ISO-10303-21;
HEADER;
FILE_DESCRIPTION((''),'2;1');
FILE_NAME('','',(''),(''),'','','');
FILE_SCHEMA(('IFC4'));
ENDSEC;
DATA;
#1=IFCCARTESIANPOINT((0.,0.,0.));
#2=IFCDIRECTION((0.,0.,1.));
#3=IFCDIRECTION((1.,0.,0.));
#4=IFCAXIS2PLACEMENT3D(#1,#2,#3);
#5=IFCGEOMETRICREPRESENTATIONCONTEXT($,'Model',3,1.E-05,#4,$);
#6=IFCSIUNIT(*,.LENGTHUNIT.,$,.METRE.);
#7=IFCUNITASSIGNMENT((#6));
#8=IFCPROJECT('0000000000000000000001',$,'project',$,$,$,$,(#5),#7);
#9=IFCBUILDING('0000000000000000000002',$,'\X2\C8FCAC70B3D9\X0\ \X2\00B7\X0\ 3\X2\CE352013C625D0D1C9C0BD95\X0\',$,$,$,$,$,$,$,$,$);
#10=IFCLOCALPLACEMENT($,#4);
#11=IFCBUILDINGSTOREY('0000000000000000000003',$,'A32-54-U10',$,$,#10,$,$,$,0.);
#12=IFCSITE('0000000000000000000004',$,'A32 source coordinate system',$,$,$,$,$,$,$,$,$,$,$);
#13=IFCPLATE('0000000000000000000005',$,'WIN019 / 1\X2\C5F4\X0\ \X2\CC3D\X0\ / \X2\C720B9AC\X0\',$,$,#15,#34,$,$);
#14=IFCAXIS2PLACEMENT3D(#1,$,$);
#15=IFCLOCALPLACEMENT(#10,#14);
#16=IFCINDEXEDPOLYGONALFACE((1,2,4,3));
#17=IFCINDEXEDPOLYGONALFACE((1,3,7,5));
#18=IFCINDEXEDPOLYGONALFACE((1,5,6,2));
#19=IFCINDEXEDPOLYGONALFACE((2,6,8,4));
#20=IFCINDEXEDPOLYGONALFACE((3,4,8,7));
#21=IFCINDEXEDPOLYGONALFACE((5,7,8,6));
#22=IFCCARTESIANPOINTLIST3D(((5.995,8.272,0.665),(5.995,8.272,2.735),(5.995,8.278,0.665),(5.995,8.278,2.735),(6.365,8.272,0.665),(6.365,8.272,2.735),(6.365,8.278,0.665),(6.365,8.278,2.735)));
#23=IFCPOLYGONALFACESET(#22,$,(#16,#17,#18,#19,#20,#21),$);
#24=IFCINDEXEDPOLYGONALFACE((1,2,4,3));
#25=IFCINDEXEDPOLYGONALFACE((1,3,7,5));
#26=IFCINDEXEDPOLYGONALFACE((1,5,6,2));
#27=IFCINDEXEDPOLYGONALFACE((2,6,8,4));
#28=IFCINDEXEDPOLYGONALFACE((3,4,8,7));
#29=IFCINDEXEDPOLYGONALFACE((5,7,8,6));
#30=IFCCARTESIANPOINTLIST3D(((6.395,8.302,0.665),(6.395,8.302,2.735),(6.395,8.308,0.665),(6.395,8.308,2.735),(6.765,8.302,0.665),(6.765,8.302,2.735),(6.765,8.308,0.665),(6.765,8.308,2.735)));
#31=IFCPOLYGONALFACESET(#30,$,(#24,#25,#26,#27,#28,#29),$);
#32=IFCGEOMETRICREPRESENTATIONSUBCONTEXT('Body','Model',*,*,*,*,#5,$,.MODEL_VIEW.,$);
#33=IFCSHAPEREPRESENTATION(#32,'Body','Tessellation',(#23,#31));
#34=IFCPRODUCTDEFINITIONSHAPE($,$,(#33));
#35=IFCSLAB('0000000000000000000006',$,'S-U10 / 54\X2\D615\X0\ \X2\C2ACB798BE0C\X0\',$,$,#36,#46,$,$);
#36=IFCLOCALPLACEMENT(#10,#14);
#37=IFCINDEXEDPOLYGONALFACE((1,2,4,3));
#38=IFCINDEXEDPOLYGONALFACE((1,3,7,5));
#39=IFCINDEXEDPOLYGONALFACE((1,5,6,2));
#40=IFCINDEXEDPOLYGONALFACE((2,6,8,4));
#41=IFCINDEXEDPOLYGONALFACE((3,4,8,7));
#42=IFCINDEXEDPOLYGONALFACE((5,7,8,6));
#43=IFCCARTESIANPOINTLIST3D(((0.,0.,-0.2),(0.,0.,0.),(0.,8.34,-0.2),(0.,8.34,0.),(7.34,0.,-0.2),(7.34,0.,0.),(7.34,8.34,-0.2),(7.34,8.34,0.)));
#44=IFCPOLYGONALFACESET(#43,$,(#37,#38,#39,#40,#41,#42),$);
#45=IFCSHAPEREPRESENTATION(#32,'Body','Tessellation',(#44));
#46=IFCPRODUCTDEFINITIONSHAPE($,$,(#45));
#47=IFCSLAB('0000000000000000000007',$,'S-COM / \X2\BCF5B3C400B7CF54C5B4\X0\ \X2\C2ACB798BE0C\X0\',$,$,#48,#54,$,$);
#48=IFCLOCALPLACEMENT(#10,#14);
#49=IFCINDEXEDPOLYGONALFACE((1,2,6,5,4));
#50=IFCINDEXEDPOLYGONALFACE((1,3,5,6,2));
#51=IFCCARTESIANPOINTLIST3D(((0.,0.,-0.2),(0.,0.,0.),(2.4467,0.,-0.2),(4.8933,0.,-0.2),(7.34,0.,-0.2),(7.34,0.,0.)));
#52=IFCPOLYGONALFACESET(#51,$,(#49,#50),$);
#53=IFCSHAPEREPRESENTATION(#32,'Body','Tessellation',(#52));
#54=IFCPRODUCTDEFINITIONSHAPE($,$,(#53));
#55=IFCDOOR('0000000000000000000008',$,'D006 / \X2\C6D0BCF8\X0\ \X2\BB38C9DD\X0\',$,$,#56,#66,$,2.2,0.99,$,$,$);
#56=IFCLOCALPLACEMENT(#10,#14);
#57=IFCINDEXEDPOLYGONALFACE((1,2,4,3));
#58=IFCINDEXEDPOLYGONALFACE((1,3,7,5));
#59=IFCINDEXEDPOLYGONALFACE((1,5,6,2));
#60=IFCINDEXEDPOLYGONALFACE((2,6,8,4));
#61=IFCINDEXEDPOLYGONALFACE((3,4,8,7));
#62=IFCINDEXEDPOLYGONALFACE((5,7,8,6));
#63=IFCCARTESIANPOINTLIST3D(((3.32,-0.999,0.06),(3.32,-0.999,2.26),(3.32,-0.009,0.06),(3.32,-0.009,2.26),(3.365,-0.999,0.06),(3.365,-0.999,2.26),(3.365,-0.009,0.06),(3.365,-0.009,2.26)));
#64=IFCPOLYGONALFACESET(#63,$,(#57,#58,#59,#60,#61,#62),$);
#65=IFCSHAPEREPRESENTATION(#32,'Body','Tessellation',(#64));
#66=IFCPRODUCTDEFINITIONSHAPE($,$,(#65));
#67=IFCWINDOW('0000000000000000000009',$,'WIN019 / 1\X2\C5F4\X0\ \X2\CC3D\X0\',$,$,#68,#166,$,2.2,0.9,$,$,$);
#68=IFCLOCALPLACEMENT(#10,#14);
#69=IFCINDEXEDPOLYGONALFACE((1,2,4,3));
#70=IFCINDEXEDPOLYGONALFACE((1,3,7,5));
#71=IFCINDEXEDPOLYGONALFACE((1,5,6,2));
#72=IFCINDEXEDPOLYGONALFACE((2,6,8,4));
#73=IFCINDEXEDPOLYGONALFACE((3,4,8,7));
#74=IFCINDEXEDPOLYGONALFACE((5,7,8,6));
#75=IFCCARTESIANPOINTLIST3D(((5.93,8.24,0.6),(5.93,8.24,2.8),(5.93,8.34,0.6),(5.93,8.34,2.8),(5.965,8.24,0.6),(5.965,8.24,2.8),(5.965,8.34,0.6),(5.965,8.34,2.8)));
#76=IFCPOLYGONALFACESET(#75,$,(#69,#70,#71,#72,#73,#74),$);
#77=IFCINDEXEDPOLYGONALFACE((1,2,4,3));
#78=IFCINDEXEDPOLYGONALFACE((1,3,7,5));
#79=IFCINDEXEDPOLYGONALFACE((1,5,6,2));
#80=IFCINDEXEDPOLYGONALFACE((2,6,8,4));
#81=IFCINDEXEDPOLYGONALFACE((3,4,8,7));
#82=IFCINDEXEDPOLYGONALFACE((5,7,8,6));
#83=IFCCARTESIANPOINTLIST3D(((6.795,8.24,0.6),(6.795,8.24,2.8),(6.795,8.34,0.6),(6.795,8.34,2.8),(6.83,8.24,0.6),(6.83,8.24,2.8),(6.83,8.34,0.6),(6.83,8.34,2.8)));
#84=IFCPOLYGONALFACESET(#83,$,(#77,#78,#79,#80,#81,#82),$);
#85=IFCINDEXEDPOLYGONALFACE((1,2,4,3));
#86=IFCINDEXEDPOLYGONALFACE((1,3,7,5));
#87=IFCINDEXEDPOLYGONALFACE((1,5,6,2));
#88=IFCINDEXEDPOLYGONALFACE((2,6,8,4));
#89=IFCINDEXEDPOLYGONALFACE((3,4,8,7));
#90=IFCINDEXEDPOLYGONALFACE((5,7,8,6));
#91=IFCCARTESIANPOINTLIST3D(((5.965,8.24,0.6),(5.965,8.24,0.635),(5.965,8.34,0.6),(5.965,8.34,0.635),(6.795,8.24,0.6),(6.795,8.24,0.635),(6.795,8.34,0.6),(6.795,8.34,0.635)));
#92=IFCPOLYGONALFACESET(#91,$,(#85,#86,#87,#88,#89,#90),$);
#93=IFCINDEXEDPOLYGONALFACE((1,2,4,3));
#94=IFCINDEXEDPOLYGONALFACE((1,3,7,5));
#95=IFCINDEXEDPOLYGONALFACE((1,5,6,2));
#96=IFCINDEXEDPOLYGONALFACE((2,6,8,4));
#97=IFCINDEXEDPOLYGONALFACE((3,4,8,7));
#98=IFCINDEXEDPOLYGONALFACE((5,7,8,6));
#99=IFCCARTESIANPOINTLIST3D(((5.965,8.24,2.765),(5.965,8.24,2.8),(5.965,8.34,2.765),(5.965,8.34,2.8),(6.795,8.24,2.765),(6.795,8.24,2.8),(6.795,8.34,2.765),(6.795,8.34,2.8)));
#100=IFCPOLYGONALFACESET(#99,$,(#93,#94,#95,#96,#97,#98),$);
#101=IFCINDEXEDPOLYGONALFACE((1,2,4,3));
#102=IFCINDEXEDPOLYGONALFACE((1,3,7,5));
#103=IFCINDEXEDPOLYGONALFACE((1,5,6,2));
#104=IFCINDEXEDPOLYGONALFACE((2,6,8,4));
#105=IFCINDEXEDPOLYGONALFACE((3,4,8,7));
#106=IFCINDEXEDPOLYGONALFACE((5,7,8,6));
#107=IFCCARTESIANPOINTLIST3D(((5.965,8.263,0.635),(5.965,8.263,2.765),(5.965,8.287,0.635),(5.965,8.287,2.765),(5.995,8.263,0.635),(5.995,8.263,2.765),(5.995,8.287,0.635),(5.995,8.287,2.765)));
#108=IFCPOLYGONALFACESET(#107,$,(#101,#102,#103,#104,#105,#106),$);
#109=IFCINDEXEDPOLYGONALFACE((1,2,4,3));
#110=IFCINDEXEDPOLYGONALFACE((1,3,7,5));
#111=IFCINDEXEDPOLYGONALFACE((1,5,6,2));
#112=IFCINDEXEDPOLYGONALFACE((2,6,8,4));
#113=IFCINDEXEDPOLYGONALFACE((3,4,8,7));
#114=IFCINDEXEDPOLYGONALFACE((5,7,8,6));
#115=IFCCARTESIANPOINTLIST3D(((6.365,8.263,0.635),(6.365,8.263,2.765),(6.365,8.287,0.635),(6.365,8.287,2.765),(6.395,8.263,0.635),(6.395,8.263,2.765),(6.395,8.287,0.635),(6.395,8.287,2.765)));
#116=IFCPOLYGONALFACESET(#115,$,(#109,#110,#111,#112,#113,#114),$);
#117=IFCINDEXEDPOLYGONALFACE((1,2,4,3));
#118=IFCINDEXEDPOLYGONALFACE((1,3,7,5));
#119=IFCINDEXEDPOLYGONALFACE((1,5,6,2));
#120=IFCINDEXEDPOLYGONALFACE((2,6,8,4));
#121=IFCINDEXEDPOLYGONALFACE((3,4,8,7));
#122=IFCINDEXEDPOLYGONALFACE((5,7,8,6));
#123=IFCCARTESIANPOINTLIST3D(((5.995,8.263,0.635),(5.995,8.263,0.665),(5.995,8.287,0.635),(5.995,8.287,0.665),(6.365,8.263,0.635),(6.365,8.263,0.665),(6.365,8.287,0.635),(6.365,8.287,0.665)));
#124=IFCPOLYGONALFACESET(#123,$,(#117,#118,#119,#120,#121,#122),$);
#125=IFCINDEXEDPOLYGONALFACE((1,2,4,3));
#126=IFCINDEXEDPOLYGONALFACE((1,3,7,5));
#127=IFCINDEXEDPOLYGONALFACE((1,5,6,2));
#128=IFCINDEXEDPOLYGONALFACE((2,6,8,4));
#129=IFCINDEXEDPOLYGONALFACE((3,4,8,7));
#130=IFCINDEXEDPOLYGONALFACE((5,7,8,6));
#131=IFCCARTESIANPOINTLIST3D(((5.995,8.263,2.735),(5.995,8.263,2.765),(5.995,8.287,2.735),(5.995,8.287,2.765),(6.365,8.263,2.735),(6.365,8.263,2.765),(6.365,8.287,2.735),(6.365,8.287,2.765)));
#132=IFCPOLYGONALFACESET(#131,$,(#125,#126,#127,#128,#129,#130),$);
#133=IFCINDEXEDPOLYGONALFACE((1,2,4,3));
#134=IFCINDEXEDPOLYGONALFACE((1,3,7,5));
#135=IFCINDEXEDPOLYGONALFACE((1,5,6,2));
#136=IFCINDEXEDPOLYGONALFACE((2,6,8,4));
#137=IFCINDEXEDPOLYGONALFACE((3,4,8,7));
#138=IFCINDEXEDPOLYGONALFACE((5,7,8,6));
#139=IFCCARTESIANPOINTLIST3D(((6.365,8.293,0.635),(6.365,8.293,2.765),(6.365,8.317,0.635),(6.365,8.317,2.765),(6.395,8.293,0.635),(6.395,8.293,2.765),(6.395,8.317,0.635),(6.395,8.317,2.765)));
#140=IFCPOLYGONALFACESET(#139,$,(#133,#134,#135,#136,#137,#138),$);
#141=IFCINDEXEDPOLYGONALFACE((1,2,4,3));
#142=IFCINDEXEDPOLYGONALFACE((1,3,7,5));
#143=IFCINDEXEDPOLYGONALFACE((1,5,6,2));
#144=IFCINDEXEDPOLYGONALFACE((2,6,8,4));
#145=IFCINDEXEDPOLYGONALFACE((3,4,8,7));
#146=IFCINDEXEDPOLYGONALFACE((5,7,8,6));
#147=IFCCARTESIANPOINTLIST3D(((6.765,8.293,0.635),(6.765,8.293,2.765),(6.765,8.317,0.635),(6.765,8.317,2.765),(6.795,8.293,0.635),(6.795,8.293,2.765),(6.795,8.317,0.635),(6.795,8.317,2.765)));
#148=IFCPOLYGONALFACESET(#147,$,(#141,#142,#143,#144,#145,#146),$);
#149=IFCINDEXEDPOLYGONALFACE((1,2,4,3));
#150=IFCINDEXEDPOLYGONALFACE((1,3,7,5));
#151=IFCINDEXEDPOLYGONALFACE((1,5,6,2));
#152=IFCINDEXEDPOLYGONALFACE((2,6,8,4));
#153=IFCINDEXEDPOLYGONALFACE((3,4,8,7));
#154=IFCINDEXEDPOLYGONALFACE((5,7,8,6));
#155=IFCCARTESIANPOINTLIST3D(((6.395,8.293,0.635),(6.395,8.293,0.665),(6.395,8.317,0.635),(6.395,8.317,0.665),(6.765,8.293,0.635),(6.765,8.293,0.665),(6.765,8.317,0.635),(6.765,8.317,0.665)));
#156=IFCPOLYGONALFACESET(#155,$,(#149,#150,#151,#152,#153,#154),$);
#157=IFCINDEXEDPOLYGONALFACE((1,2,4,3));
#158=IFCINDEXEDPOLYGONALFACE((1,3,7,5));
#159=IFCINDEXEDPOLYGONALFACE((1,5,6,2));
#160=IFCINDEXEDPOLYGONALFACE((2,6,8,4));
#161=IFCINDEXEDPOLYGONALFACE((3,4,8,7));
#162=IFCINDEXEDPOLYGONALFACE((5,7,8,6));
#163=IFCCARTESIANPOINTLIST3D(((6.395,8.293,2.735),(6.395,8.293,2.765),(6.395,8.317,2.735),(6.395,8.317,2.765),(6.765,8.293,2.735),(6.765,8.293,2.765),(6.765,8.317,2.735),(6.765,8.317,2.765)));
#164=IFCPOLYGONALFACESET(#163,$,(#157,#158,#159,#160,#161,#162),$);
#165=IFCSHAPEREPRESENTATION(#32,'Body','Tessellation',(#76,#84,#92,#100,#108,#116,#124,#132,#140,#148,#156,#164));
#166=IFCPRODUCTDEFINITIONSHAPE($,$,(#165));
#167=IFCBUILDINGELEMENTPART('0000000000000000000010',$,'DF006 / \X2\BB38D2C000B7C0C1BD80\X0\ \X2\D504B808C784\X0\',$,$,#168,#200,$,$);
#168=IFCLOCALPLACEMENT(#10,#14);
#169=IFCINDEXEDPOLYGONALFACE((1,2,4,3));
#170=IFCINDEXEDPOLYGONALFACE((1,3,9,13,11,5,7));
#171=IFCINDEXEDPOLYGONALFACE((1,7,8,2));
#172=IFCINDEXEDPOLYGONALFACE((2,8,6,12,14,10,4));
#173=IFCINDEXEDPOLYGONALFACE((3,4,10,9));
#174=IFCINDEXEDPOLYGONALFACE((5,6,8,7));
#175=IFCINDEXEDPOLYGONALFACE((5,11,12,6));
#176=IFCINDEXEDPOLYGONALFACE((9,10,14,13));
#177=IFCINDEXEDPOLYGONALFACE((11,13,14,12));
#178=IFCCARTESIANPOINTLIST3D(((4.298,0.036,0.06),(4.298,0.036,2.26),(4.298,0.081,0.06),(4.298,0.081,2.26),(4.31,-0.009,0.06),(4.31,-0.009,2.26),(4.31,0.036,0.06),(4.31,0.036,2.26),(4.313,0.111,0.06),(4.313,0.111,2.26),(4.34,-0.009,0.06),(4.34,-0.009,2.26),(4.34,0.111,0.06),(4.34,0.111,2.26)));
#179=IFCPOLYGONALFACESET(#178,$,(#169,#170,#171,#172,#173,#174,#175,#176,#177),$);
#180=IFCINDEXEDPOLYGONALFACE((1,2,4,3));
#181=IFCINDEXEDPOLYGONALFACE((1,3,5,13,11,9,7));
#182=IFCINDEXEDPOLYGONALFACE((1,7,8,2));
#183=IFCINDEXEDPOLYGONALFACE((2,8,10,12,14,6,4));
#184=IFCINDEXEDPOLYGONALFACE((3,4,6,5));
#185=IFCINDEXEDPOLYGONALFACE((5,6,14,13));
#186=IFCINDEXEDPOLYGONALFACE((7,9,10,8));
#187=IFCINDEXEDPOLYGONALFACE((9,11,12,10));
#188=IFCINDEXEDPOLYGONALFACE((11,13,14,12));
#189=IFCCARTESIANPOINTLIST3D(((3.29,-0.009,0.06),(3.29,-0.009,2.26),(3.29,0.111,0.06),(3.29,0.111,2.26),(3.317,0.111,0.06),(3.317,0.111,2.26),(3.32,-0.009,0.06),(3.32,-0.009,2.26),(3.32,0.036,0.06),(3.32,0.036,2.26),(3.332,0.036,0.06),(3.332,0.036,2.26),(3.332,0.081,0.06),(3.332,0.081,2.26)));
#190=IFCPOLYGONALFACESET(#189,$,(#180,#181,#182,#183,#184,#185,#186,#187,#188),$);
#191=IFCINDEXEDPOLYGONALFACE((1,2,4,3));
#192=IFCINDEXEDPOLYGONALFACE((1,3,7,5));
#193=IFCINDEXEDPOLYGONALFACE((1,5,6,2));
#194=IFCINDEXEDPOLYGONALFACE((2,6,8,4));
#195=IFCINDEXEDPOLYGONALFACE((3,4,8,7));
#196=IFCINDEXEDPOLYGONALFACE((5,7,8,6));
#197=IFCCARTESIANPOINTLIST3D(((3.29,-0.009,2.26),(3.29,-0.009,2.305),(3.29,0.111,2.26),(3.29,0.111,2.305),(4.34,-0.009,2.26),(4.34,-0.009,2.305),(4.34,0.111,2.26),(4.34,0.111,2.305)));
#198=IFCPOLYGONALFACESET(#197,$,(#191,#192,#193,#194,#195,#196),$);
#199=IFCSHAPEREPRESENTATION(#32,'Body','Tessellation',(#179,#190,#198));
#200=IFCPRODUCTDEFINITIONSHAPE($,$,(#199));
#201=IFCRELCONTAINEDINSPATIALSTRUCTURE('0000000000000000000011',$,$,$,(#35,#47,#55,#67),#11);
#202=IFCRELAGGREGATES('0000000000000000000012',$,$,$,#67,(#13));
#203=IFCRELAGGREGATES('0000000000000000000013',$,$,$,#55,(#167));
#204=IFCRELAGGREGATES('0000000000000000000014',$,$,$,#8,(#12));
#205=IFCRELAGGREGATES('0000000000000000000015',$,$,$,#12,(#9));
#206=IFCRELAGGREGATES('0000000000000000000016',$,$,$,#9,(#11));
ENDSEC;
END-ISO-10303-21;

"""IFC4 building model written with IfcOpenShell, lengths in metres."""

from ifc_helpers import new_model, si_unit, frame, origin_with_axes, place, context, subcontext, project, spatial, polyline, outline, extrude, element, aggregate, save


model = new_model("IFC4")

# Units and contexts
model_context = context("Model", 3, precision=1e-05, world=origin_with_axes())
body_context = subcontext(model_context, "Body", "Model", "MODEL_VIEW")
ifc_project = project(units=[si_unit("LENGTHUNIT", "METRE")], contexts=[model_context])

# Plate
storey_placement = place(None, origin_with_axes())
window_1_placement = place(storey_placement, origin_with_axes())
plate_1_placement = place(window_1_placement, origin_with_axes())
plate_1 = element("IfcPlate", 1, at=plate_1_placement, Name="WIN019 / 1열 창 / 유리", context=body_context, shape_type="SweptSolid", body=[
    extrude(outline(polyline([(5.995, 8.272), (5.995, 8.278), (6.365, 8.278), (6.365, 8.272), (5.995, 8.272)])), frame((0.0, 0.0, 0.665)), (0.0, 0.0, 1.0), 2.07),
    extrude(outline(polyline([(6.395, 8.302), (6.395, 8.308), (6.765, 8.308), (6.765, 8.302), (6.395, 8.302)])), frame((0.0, 0.0, 0.665)), (0.0, 0.0, 1.0), 2.07),
])

# Site, building, storey
site = spatial("IfcSite", under=ifc_project, Name="A32 source coordinate system")
building = spatial("IfcBuilding", under=site, Name="주거동 · 3층–옥탑지붕")
storey = spatial("IfcBuildingStorey", under=building, at=storey_placement, Name="A32-54-U10", Elevation=0.0)

# Slabs
slab_1_placement = place(storey_placement, origin_with_axes())
element("IfcSlab", 2, at=slab_1_placement, inside=storey, Name="S-U10 / 54형 슬래브", context=body_context, shape_type="SweptSolid", body=[
    extrude(outline(polyline([(0.0, 0.0), (0.0, 8.34), (7.34, 8.34), (7.34, 0.0), (0.0, 0.0)])), frame((0.0, 0.0, -0.2)), (0.0, 0.0, 1.0), 0.2),
])
slab_2_placement = place(storey_placement, origin_with_axes())
element("IfcSlab", 3, at=slab_2_placement, inside=storey, Name="S-COM / 복도·코어 슬래브", context=body_context, shape_type="SweptSolid", body=[
    extrude(outline(polyline([(7.34, 0.0), (7.34, 0.0), (0.0, 0.0), (0.0, 0.0), (7.34, 0.0)])), frame((0.0, 0.0, -0.2)), (0.0, 0.0, 1.0), 0.2),
])

# Door
door_1_placement = place(storey_placement, origin_with_axes())
door_1 = element("IfcDoor", 4, at=door_1_placement, inside=storey, Name="D006 / 원본 문짝", OverallHeight=2.2, OverallWidth=0.99, context=body_context, shape_type="SweptSolid", body=[
    extrude(outline(polyline([(3.365, -0.999), (3.32, -0.999), (3.32, -0.009), (3.365, -0.009), (3.365, -0.999)])), frame((0.0, 0.0, 0.06)), (0.0, 0.0, 1.0), 2.2),
])

# Window
window_1 = element("IfcWindow", 5, at=window_1_placement, inside=storey, Name="WIN019 / 1열 창", OverallHeight=2.2, OverallWidth=0.9, context=body_context, shape_type="SweptSolid", body=[
    extrude(outline(polyline([(5.93, 8.24), (5.93, 8.34), (5.965, 8.34), (5.965, 8.24), (5.93, 8.24)])), frame((0.0, 0.0, 0.6)), (0.0, 0.0, 1.0), 2.2),
    extrude(outline(polyline([(6.795, 8.24), (6.795, 8.34), (6.83, 8.34), (6.83, 8.24), (6.795, 8.24)])), frame((0.0, 0.0, 0.6)), (0.0, 0.0, 1.0), 2.2),
    extrude(outline(polyline([(5.965, 8.24), (5.965, 8.34), (6.795, 8.34), (6.795, 8.24), (5.965, 8.24)])), frame((0.0, 0.0, 0.6)), (0.0, 0.0, 1.0), 0.035),
    extrude(outline(polyline([(5.965, 8.24), (5.965, 8.34), (6.795, 8.34), (6.795, 8.24), (5.965, 8.24)])), frame((0.0, 0.0, 2.765)), (0.0, 0.0, 1.0), 0.035),
    extrude(outline(polyline([(5.965, 8.263), (5.965, 8.287), (5.995, 8.287), (5.995, 8.263), (5.965, 8.263)])), frame((0.0, 0.0, 0.635)), (0.0, 0.0, 1.0), 2.13),
    extrude(outline(polyline([(6.365, 8.263), (6.365, 8.287), (6.395, 8.287), (6.395, 8.263), (6.365, 8.263)])), frame((0.0, 0.0, 0.635)), (0.0, 0.0, 1.0), 2.13),
    extrude(outline(polyline([(5.995, 8.263), (5.995, 8.287), (6.365, 8.287), (6.365, 8.263), (5.995, 8.263)])), frame((0.0, 0.0, 0.635)), (0.0, 0.0, 1.0), 0.03),
    extrude(outline(polyline([(5.995, 8.263), (5.995, 8.287), (6.365, 8.287), (6.365, 8.263), (5.995, 8.263)])), frame((0.0, 0.0, 2.735)), (0.0, 0.0, 1.0), 0.03),
    extrude(outline(polyline([(6.365, 8.293), (6.365, 8.317), (6.395, 8.317), (6.395, 8.293), (6.365, 8.293)])), frame((0.0, 0.0, 0.635)), (0.0, 0.0, 1.0), 2.13),
    extrude(outline(polyline([(6.765, 8.293), (6.765, 8.317), (6.795, 8.317), (6.795, 8.293), (6.765, 8.293)])), frame((0.0, 0.0, 0.635)), (0.0, 0.0, 1.0), 2.13),
    extrude(outline(polyline([(6.395, 8.293), (6.395, 8.317), (6.765, 8.317), (6.765, 8.293), (6.395, 8.293)])), frame((0.0, 0.0, 0.635)), (0.0, 0.0, 1.0), 0.03),
    extrude(outline(polyline([(6.395, 8.293), (6.395, 8.317), (6.765, 8.317), (6.765, 8.293), (6.395, 8.293)])), frame((0.0, 0.0, 2.735)), (0.0, 0.0, 1.0), 0.03),
])
aggregate(window_1, [plate_1])

# Building element part
building_element_part_1_placement = place(door_1_placement, origin_with_axes())
building_element_part_1 = element("IfcBuildingElementPart", 6, at=building_element_part_1_placement, Name="DF006 / 문틀·상부 프레임", context=body_context, shape_type="SweptSolid", body=[
    extrude(outline(polyline([(4.31, -0.009), (4.31, 0.036), (4.298, 0.036), (4.298, 0.081), (4.313, 0.111), (4.34, 0.111), (4.34, -0.009), (4.31, -0.009)])), frame((0.0, 0.0, 0.06)), (0.0, 0.0, 1.0), 2.2),
    extrude(outline(polyline([(3.29, 0.111), (3.317, 0.111), (3.332, 0.081), (3.332, 0.036), (3.32, 0.036), (3.32, -0.009), (3.29, -0.009), (3.29, 0.111)])), frame((0.0, 0.0, 0.06)), (0.0, 0.0, 1.0), 2.2),
    extrude(outline(polyline([(3.29, -0.009), (3.29, 0.111), (4.34, 0.111), (4.34, -0.009), (3.29, -0.009)])), frame((0.0, 0.0, 2.26)), (0.0, 0.0, 1.0), 0.045),
])
aggregate(door_1, [building_element_part_1])

save(model, "model.ifc")
